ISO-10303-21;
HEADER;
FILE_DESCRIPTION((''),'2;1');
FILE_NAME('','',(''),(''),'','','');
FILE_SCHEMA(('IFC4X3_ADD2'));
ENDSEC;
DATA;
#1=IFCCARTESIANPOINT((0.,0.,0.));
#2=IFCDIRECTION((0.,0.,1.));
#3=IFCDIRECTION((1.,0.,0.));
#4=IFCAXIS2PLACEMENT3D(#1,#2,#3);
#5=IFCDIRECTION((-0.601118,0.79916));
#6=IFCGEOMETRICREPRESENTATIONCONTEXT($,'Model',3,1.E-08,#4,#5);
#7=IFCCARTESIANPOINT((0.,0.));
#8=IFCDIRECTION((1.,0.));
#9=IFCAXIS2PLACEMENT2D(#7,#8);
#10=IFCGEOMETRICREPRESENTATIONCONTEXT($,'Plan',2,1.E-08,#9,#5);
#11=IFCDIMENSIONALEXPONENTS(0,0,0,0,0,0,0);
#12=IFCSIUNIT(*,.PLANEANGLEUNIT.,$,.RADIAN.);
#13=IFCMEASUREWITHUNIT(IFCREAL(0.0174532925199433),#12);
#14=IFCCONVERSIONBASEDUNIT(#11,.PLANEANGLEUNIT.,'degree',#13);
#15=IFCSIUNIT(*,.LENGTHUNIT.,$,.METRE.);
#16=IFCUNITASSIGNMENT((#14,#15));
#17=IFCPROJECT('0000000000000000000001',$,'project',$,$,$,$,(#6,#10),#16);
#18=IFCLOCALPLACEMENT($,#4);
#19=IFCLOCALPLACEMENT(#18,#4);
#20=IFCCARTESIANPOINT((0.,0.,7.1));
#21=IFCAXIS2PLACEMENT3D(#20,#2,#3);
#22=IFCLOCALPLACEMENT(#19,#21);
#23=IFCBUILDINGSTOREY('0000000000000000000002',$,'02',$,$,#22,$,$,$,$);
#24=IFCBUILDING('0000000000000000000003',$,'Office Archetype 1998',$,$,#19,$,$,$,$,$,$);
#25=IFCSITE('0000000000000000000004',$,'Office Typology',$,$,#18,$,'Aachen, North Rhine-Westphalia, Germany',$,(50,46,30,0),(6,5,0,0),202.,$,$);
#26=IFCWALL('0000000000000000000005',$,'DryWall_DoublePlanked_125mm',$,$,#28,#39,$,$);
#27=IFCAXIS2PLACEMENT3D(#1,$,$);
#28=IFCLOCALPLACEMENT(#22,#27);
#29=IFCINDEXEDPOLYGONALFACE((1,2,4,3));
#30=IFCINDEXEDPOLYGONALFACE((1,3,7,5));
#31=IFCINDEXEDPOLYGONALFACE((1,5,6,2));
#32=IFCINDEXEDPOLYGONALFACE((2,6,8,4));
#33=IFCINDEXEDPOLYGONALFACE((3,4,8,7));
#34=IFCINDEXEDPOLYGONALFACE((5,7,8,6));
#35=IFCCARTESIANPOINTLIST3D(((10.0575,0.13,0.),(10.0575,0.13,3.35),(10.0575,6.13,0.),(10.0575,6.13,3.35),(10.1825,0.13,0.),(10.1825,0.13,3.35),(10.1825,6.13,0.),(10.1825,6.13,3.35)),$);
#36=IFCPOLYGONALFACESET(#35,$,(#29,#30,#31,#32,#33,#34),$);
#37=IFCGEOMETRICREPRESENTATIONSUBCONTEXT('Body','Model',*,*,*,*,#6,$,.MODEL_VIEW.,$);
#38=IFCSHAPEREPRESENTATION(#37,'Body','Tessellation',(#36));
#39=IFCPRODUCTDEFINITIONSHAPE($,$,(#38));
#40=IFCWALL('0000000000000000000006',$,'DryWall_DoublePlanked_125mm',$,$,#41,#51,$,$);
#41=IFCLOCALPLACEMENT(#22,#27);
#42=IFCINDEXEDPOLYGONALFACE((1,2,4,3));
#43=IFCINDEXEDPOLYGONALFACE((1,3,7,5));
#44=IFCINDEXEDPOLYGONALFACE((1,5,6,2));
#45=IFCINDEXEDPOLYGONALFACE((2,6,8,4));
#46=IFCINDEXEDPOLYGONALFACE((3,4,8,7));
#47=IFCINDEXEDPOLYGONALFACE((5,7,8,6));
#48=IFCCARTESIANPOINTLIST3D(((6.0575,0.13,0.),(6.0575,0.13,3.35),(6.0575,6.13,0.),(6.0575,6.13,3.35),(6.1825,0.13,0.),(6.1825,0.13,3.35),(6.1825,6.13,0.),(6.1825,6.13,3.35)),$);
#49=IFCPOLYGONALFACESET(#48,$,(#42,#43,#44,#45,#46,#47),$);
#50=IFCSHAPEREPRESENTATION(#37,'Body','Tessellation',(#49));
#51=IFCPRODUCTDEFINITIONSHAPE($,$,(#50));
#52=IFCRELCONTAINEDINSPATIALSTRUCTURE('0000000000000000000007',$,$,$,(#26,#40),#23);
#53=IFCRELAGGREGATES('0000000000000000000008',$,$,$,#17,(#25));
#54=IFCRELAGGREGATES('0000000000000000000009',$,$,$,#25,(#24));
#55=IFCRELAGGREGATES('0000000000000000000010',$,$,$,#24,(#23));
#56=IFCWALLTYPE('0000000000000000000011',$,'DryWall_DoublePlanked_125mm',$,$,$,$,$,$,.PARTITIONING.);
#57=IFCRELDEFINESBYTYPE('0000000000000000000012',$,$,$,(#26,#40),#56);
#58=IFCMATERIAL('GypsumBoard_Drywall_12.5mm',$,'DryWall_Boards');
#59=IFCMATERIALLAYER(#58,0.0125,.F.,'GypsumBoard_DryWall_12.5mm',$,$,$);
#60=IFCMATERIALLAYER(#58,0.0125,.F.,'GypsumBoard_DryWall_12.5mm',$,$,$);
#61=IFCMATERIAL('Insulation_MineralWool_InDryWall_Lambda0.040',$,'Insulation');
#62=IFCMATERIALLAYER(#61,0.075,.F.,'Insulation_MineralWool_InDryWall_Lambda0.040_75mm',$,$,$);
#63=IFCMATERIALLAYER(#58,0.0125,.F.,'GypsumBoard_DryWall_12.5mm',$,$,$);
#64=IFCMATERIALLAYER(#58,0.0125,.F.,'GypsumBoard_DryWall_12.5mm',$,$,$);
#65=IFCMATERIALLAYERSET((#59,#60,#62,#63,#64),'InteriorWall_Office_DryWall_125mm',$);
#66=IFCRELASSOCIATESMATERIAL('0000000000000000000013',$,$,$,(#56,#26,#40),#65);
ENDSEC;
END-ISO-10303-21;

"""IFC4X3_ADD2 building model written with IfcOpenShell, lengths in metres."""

from ifc_helpers import new_model, entity, si_unit, converted_unit, direction, frame, origin_with_axes, origin_2d_with_axis, place, context, subcontext, project, spatial, line, indexed_curve, outline, extrude, material, layer, layer_set, layer_usage, type_object, element, save


model = new_model("IFC4X3_ADD2")

# Units and contexts
model_context = context("Model", 3, precision=1e-08, world=origin_with_axes(), true_north=direction((-0.601118, 0.79916)))
plan_context = context("Plan", 2, precision=1e-08, world=origin_2d_with_axis(), true_north=direction((-0.601118, 0.79916)))
body_context = subcontext(model_context, "Body", "Model", "MODEL_VIEW")
ifc_project = project(units=[converted_unit("PLANEANGLEUNIT", "degree", entity("IfcReal", 0.0174532925199433), si_unit("PLANEANGLEUNIT", "RADIAN"), dimensions=[0, 0, 0, 0, 0, 0, 0]), si_unit("LENGTHUNIT", "METRE")], contexts=[model_context, plan_context])

# Site, building, storey
site_placement = place(None, origin_with_axes())
site = spatial("IfcSite", under=ifc_project, at=site_placement, Name="Office Typology", LongName="Aachen, North Rhine-Westphalia, Germany", RefLatitude=(50, 46, 30, 0), RefLongitude=(6, 5, 0, 0), RefElevation=202.0)
building_placement = place(site_placement, origin_with_axes())
building = spatial("IfcBuilding", under=site, at=building_placement, Name="Office Archetype 1998")
storey_placement = place(building_placement, frame((0.0, 0.0, 7.1), z_axis=(0.0, 0.0, 1.0), x_axis=(1.0, 0.0, 0.0)))
storey = spatial("IfcBuildingStorey", under=building, at=storey_placement, Name="02")

# Walls
ifc_material_1 = material(Name="GypsumBoard_Drywall_12.5mm", Category="DryWall_Boards")
ifc_layer_1 = layer(ifc_material_1, 0.0125, ventilated=False, Name="GypsumBoard_DryWall_12.5mm")
ifc_layer_2 = layer(ifc_material_1, 0.0125, ventilated=False, Name="GypsumBoard_DryWall_12.5mm")
ifc_material_2 = material(Name="Insulation_MineralWool_InDryWall_Lambda0.040", Category="Insulation")
ifc_layer_3 = layer(ifc_material_2, 0.075, ventilated=False, Name="Insulation_MineralWool_InDryWall_Lambda0.040_75mm")
ifc_layer_4 = layer(ifc_material_1, 0.0125, ventilated=False, Name="GypsumBoard_DryWall_12.5mm")
ifc_layer_5 = layer(ifc_material_1, 0.0125, ventilated=False, Name="GypsumBoard_DryWall_12.5mm")
ifc_layer_set_1 = layer_set([ifc_layer_1, ifc_layer_2, ifc_layer_3, ifc_layer_4, ifc_layer_5], Name="InteriorWall_Office_DryWall_125mm")
ifc_layer_usage_1 = layer_usage(ifc_layer_set_1, "AXIS2", "POSITIVE", 0.0)
wall_type_1 = type_object("IfcWallType", Name="DryWall_DoublePlanked_125mm", PredefinedType="PARTITIONING", material=ifc_layer_set_1)
wall_1_placement = place(storey_placement, frame((10.0575, 6.13, 0.0), z_axis=(0.0, 0.0, 1.0), x_axis=(0.0, -1.0, 0.0)))
element("IfcWall", 1, at=wall_1_placement, inside=storey, type_object=wall_type_1, material=ifc_layer_usage_1, Name="DryWall_DoublePlanked_125mm", context=body_context, shape_type="SweptSolid", body=[
    extrude(outline(indexed_curve([(0.0, 0.0), (0.0, 0.125), (6.0, 0.125), (6.0, 0.0)], segments=[line(1, 2, 3, 4, 1)])), origin_with_axes(), (0.0, 0.0, 1.0), 3.35),
])
ifc_layer_usage_2 = layer_usage(ifc_layer_set_1, "AXIS2", "POSITIVE", 0.0)
wall_2_placement = place(storey_placement, frame((6.0575, 6.13, 0.0), z_axis=(0.0, 0.0, 1.0), x_axis=(0.0, -1.0, 0.0)))
element("IfcWall", 2, at=wall_2_placement, inside=storey, type_object=wall_type_1, material=ifc_layer_usage_2, Name="DryWall_DoublePlanked_125mm", context=body_context, shape_type="SweptSolid", body=[
    extrude(outline(indexed_curve([(0.0, 0.0), (0.0, 0.125), (6.0, 0.125), (6.0, 0.0)], segments=[line(1, 2, 3, 4, 1)])), origin_with_axes(), (0.0, 0.0, 1.0), 3.35),
])

save(model, "model.ifc")
